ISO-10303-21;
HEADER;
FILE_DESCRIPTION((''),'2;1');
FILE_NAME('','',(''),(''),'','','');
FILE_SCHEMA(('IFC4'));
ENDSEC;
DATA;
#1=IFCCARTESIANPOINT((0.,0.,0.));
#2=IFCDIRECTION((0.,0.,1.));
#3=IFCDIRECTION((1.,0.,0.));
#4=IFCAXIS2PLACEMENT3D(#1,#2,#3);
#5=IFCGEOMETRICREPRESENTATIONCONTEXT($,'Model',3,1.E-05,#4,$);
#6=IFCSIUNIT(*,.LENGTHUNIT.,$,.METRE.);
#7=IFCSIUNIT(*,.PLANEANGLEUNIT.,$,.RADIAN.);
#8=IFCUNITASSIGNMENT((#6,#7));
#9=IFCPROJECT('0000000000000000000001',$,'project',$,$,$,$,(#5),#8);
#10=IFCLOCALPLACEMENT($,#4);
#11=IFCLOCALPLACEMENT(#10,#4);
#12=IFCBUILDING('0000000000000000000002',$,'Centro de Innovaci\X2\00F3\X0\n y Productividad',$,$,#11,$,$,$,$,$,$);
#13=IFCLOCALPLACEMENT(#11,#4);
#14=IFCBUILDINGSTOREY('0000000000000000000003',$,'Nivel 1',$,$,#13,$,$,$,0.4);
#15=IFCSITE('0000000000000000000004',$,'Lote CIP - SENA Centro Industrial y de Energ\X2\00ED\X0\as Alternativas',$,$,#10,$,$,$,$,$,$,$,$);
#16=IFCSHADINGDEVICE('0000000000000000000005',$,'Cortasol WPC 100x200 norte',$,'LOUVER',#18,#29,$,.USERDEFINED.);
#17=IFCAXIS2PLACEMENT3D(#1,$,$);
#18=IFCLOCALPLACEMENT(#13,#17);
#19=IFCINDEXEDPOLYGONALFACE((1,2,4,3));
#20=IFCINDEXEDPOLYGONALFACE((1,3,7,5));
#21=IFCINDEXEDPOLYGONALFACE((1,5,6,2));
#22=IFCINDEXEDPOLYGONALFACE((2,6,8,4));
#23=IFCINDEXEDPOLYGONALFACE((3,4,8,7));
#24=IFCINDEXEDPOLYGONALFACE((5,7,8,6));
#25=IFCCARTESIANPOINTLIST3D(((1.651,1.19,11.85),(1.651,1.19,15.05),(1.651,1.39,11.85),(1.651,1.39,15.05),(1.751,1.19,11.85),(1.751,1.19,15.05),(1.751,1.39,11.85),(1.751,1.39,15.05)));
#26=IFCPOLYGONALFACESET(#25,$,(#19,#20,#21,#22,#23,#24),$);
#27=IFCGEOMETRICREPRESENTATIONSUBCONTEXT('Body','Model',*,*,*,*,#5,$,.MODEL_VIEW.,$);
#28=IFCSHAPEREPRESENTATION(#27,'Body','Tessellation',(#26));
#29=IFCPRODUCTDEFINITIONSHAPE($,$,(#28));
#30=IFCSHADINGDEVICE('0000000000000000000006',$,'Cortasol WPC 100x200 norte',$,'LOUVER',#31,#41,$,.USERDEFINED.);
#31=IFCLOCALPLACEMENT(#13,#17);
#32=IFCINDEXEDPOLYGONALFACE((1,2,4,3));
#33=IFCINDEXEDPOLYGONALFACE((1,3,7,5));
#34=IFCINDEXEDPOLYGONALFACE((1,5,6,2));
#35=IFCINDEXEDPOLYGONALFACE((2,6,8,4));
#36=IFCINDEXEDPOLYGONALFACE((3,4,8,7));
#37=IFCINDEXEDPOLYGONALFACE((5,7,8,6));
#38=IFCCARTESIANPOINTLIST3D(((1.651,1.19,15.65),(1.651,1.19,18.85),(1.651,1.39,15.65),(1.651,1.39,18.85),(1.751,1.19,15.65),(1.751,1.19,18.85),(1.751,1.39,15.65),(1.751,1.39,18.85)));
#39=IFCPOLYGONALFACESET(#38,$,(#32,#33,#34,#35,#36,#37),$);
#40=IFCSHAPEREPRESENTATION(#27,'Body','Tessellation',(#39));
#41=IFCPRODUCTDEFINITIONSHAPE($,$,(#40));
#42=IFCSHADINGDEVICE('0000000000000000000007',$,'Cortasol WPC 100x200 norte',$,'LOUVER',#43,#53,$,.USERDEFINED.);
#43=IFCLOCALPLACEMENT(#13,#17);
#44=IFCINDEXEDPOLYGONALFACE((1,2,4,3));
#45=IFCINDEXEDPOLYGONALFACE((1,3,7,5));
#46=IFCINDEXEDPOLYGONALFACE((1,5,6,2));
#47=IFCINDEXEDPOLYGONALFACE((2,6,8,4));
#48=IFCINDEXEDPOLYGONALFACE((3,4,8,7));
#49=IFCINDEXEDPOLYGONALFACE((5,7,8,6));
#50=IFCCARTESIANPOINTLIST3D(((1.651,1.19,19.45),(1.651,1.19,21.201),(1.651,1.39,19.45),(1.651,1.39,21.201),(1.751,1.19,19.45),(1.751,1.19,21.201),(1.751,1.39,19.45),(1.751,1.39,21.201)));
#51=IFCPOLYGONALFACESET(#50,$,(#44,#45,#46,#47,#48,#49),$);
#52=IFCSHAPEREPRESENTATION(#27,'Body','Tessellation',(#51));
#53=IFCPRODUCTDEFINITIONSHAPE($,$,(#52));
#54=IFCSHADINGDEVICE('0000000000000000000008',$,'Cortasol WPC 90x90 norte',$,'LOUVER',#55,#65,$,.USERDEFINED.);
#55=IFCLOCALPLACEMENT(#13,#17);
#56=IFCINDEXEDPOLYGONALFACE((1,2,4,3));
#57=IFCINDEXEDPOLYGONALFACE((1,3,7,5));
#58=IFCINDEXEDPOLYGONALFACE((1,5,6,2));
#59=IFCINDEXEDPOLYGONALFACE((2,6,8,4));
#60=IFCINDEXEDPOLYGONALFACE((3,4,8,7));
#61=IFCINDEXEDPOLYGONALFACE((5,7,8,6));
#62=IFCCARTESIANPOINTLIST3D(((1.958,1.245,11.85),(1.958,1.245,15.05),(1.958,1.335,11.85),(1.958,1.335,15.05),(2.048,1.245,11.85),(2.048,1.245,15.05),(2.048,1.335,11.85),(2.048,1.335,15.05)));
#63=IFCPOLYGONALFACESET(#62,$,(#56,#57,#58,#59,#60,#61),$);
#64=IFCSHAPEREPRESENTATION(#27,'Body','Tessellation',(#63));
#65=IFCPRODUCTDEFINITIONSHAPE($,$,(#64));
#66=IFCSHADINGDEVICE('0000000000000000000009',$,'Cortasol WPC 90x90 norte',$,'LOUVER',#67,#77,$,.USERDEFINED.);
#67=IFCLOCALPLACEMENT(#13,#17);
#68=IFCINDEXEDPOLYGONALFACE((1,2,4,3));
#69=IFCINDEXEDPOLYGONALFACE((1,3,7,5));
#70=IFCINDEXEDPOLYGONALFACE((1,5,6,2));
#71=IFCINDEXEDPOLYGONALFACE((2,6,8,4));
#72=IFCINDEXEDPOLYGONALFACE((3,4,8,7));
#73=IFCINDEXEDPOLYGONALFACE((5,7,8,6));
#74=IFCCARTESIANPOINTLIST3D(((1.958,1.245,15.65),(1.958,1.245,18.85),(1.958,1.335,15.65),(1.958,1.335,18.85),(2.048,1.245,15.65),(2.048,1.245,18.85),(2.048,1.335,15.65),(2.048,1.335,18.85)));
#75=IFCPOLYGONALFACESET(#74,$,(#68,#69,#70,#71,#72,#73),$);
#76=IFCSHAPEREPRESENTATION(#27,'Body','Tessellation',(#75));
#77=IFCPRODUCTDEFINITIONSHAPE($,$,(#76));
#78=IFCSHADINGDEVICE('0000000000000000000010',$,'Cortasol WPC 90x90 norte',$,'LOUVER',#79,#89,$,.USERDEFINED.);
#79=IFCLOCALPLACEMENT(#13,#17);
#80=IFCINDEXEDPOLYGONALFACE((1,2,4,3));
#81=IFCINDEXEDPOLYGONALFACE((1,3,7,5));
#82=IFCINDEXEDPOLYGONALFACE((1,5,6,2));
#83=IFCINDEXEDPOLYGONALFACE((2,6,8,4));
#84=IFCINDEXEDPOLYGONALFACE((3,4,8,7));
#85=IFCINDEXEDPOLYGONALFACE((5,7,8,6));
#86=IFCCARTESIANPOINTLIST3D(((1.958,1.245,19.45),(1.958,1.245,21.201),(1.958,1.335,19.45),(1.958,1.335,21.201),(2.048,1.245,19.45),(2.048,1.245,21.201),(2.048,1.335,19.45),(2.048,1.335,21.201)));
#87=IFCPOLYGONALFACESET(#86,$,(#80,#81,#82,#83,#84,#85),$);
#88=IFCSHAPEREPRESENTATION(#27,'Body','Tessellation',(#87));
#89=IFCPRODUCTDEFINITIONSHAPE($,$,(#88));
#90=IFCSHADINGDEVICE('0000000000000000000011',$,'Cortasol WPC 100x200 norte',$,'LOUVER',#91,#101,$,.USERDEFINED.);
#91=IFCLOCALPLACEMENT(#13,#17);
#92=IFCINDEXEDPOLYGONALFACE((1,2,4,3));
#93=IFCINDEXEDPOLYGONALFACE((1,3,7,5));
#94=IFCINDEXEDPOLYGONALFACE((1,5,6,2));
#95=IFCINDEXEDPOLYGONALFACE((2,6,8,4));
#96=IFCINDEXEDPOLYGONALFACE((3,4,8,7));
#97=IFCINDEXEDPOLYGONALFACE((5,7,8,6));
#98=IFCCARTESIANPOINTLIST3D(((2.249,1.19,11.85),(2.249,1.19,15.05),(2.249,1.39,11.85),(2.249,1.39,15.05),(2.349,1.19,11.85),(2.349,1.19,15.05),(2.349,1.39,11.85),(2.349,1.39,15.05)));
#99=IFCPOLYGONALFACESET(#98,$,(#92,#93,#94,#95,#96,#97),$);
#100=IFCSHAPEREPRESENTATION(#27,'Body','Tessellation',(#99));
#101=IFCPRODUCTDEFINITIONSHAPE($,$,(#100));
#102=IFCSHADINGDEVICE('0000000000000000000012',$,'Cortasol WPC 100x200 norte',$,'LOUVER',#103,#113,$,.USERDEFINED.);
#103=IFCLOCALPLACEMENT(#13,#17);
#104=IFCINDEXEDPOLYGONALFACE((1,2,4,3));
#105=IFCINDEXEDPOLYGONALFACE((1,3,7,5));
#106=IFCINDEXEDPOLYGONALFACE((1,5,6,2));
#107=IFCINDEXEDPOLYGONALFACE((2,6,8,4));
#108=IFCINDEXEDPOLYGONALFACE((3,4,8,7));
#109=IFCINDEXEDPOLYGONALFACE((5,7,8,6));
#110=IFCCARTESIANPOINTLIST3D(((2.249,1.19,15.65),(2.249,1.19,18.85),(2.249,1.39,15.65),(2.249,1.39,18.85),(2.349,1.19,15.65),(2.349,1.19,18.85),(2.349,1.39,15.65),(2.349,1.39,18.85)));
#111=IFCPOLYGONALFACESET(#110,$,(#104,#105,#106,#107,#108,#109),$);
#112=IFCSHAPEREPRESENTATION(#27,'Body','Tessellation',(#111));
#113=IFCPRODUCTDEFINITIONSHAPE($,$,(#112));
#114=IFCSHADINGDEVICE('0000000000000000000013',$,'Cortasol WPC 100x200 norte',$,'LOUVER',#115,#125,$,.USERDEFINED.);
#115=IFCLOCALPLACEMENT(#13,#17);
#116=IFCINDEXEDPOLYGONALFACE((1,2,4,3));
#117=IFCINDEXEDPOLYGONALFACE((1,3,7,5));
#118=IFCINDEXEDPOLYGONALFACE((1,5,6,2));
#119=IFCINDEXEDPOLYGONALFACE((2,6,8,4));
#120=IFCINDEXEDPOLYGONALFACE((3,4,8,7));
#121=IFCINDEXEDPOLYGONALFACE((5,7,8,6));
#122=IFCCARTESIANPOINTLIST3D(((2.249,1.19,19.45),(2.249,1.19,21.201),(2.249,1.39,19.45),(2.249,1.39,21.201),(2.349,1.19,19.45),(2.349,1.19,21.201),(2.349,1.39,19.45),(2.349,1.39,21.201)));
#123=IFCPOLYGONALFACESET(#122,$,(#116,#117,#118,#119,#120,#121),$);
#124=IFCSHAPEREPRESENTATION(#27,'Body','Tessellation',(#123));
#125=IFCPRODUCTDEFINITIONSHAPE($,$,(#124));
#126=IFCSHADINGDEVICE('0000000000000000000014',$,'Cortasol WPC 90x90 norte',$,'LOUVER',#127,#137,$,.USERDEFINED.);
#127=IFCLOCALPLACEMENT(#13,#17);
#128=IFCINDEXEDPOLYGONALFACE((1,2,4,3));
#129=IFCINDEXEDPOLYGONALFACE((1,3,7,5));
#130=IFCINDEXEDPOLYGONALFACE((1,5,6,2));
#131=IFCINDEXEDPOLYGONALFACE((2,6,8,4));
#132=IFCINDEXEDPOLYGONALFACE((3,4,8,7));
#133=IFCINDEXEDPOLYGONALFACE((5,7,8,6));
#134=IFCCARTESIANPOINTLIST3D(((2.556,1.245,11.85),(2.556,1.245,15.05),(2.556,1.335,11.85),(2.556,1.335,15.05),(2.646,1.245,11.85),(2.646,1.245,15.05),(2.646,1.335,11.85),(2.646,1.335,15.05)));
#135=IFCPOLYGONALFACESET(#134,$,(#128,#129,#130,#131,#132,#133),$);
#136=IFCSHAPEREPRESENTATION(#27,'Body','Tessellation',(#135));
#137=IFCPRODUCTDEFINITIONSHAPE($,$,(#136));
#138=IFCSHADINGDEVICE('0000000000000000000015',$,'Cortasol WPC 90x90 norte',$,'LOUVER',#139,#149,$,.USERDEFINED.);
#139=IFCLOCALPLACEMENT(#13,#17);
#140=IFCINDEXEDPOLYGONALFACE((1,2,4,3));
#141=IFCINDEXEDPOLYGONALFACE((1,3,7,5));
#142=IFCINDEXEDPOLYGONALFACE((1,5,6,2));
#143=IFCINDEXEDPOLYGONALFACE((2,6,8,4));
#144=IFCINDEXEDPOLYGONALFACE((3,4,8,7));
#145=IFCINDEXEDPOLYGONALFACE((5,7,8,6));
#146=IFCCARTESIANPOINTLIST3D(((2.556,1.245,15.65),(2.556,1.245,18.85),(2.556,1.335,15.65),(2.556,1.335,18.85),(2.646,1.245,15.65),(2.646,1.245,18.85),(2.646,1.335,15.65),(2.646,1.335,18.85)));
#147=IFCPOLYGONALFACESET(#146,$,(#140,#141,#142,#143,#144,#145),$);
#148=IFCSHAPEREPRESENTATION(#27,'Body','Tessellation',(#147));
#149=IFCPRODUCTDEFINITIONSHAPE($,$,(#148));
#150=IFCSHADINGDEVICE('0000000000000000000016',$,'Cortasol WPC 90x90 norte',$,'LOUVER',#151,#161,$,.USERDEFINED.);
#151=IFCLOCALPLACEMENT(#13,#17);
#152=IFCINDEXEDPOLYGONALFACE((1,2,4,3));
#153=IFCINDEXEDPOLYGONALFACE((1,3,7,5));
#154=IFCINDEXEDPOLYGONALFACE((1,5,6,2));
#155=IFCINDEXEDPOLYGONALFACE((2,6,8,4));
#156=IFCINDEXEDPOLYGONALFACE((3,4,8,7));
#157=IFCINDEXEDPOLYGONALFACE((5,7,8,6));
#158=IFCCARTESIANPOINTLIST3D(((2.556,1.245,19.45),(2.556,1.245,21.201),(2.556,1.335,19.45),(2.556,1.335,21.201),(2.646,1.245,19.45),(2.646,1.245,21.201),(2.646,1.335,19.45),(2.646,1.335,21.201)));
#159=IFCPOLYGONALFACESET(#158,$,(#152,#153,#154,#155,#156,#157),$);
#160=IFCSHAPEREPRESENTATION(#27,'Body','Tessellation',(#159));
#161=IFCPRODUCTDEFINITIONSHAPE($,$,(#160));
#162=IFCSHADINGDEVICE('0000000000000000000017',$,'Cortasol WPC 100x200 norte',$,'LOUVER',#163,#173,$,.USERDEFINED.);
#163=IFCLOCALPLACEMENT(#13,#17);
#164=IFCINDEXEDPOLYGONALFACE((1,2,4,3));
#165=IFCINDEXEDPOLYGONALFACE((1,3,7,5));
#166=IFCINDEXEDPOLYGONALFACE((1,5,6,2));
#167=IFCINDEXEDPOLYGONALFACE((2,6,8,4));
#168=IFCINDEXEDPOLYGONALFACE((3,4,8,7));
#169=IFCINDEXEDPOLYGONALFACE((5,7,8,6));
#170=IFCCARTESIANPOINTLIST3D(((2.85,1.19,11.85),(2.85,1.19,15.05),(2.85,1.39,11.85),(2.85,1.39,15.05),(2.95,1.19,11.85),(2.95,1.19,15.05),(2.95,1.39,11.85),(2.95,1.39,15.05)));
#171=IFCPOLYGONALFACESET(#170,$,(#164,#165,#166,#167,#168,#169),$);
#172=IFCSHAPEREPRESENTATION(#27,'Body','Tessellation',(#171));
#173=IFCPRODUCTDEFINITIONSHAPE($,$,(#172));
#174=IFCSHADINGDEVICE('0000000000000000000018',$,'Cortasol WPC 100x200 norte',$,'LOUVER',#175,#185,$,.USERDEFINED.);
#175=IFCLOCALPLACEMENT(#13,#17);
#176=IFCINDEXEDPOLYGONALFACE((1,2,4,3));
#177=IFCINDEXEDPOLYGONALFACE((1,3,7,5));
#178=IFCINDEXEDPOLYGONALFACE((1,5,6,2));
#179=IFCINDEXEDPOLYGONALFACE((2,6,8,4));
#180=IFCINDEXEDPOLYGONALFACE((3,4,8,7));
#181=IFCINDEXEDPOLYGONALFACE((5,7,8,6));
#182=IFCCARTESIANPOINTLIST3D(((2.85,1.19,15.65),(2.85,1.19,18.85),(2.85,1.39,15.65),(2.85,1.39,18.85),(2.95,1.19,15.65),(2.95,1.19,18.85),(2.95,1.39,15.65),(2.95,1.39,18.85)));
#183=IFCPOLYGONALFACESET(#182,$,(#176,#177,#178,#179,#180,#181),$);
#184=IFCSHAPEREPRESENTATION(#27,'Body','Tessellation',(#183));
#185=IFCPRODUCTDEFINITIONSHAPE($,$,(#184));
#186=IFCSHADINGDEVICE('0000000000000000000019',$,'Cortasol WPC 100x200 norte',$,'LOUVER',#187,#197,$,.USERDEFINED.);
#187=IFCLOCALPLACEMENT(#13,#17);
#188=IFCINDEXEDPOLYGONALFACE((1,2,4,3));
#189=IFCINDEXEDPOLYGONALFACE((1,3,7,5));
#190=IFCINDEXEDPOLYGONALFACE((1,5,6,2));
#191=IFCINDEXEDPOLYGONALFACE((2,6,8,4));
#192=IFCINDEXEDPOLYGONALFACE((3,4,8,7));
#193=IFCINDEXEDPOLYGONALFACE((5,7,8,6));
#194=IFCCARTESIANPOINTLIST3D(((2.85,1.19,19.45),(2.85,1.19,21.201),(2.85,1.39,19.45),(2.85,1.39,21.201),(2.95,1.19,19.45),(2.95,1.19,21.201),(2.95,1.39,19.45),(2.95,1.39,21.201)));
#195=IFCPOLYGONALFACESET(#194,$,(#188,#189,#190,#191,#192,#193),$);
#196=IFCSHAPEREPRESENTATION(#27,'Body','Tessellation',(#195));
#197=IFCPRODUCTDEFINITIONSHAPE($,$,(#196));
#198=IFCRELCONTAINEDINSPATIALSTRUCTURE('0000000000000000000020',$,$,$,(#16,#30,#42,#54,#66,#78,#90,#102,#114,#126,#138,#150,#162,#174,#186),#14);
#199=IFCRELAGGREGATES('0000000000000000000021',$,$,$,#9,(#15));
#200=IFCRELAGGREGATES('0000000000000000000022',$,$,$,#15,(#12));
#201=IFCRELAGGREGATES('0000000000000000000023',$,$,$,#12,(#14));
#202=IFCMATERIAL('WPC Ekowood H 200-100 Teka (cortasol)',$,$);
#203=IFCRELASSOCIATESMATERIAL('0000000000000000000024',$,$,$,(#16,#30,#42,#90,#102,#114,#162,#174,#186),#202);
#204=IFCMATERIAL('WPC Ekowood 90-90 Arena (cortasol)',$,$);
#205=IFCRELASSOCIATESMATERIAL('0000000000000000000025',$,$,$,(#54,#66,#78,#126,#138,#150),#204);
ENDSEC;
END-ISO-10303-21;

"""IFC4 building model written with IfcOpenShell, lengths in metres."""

from ifc_helpers import new_model, si_unit, frame, origin_with_axes, place, context, subcontext, project, spatial, polyline, outline, extrude, material, element, save


model = new_model("IFC4")

# Units and contexts
model_context = context("Model", 3, precision=1e-05, world=origin_with_axes())
body_context = subcontext(model_context, "Body", "Model", "MODEL_VIEW")
ifc_project = project(units=[si_unit("LENGTHUNIT", "METRE"), si_unit("PLANEANGLEUNIT", "RADIAN")], contexts=[model_context])

# Site, building, storey
site_placement = place(None, origin_with_axes())
site = spatial("IfcSite", under=ifc_project, at=site_placement, Name="Lote CIP - SENA Centro Industrial y de Energías Alternativas")
building_placement = place(site_placement, origin_with_axes())
building = spatial("IfcBuilding", under=site, at=building_placement, Name="Centro de Innovación y Productividad")
storey_placement = place(building_placement, origin_with_axes())
storey = spatial("IfcBuildingStorey", under=building, at=storey_placement, Name="Nivel 1", Elevation=0.4)

# Shading devices
ifc_material_1 = material(Name="WPC Ekowood H 200-100 Teka (cortasol)")
shading_device_1_placement = place(storey_placement, origin_with_axes())
element("IfcShadingDevice", 1, at=shading_device_1_placement, inside=storey, material=ifc_material_1, Name="Cortasol WPC 100x200 norte", ObjectType="LOUVER", PredefinedType="USERDEFINED", context=body_context, shape_type="SweptSolid", body=[
    extrude(outline(polyline([(1.651, 1.19), (1.651, 1.39), (1.751, 1.39), (1.751, 1.19), (1.651, 1.19)])), frame((0.0, 0.0, 11.85)), (0.0, 0.0, 1.0), 3.2),
])
shading_device_2_placement = place(storey_placement, origin_with_axes())
element("IfcShadingDevice", 2, at=shading_device_2_placement, inside=storey, material=ifc_material_1, Name="Cortasol WPC 100x200 norte", ObjectType="LOUVER", PredefinedType="USERDEFINED", context=body_context, shape_type="SweptSolid", body=[
    extrude(outline(polyline([(1.651, 1.19), (1.651, 1.39), (1.751, 1.39), (1.751, 1.19), (1.651, 1.19)])), frame((0.0, 0.0, 15.65)), (0.0, 0.0, 1.0), 3.2),
])
shading_device_3_placement = place(storey_placement, origin_with_axes())
element("IfcShadingDevice", 3, at=shading_device_3_placement, inside=storey, material=ifc_material_1, Name="Cortasol WPC 100x200 norte", ObjectType="LOUVER", PredefinedType="USERDEFINED", context=body_context, shape_type="SweptSolid", body=[
    extrude(outline(polyline([(1.651, 1.19), (1.651, 1.39), (1.751, 1.39), (1.751, 1.19), (1.651, 1.19)])), frame((0.0, 0.0, 19.45)), (0.0, 0.0, 1.0), 1.751),
])
ifc_material_2 = material(Name="WPC Ekowood 90-90 Arena (cortasol)")
shading_device_4_placement = place(storey_placement, origin_with_axes())
element("IfcShadingDevice", 4, at=shading_device_4_placement, inside=storey, material=ifc_material_2, Name="Cortasol WPC 90x90 norte", ObjectType="LOUVER", PredefinedType="USERDEFINED", context=body_context, shape_type="SweptSolid", body=[
    extrude(outline(polyline([(1.958, 1.245), (1.958, 1.335), (2.048, 1.335), (2.048, 1.245), (1.958, 1.245)])), frame((0.0, 0.0, 11.85)), (0.0, 0.0, 1.0), 3.2),
])
shading_device_5_placement = place(storey_placement, origin_with_axes())
element("IfcShadingDevice", 5, at=shading_device_5_placement, inside=storey, material=ifc_material_2, Name="Cortasol WPC 90x90 norte", ObjectType="LOUVER", PredefinedType="USERDEFINED", context=body_context, shape_type="SweptSolid", body=[
    extrude(outline(polyline([(1.958, 1.245), (1.958, 1.335), (2.048, 1.335), (2.048, 1.245), (1.958, 1.245)])), frame((0.0, 0.0, 15.65)), (0.0, 0.0, 1.0), 3.2),
])
shading_device_6_placement = place(storey_placement, origin_with_axes())
element("IfcShadingDevice", 6, at=shading_device_6_placement, inside=storey, material=ifc_material_2, Name="Cortasol WPC 90x90 norte", ObjectType="LOUVER", PredefinedType="USERDEFINED", context=body_context, shape_type="SweptSolid", body=[
    extrude(outline(polyline([(1.958, 1.245), (1.958, 1.335), (2.048, 1.335), (2.048, 1.245), (1.958, 1.245)])), frame((0.0, 0.0, 19.45)), (0.0, 0.0, 1.0), 1.751),
])
shading_device_7_placement = place(storey_placement, origin_with_axes())
element("IfcShadingDevice", 7, at=shading_device_7_placement, inside=storey, material=ifc_material_1, Name="Cortasol WPC 100x200 norte", ObjectType="LOUVER", PredefinedType="USERDEFINED", context=body_context, shape_type="SweptSolid", body=[
    extrude(outline(polyline([(2.249, 1.19), (2.249, 1.39), (2.349, 1.39), (2.349, 1.19), (2.249, 1.19)])), frame((0.0, 0.0, 11.85)), (0.0, 0.0, 1.0), 3.2),
])
shading_device_8_placement = place(storey_placement, origin_with_axes())
element("IfcShadingDevice", 8, at=shading_device_8_placement, inside=storey, material=ifc_material_1, Name="Cortasol WPC 100x200 norte", ObjectType="LOUVER", PredefinedType="USERDEFINED", context=body_context, shape_type="SweptSolid", body=[
    extrude(outline(polyline([(2.249, 1.19), (2.249, 1.39), (2.349, 1.39), (2.349, 1.19), (2.249, 1.19)])), frame((0.0, 0.0, 15.65)), (0.0, 0.0, 1.0), 3.2),
])
shading_device_9_placement = place(storey_placement, origin_with_axes())
element("IfcShadingDevice", 9, at=shading_device_9_placement, inside=storey, material=ifc_material_1, Name="Cortasol WPC 100x200 norte", ObjectType="LOUVER", PredefinedType="USERDEFINED", context=body_context, shape_type="SweptSolid", body=[
    extrude(outline(polyline([(2.249, 1.19), (2.249, 1.39), (2.349, 1.39), (2.349, 1.19), (2.249, 1.19)])), frame((0.0, 0.0, 19.45)), (0.0, 0.0, 1.0), 1.751),
])
shading_device_10_placement = place(storey_placement, origin_with_axes())
element("IfcShadingDevice", 10, at=shading_device_10_placement, inside=storey, material=ifc_material_2, Name="Cortasol WPC 90x90 norte", ObjectType="LOUVER", PredefinedType="USERDEFINED", context=body_context, shape_type="SweptSolid", body=[
    extrude(outline(polyline([(2.556, 1.245), (2.556, 1.335), (2.646, 1.335), (2.646, 1.245), (2.556, 1.245)])), frame((0.0, 0.0, 11.85)), (0.0, 0.0, 1.0), 3.2),
])
shading_device_11_placement = place(storey_placement, origin_with_axes())
element("IfcShadingDevice", 11, at=shading_device_11_placement, inside=storey, material=ifc_material_2, Name="Cortasol WPC 90x90 norte", ObjectType="LOUVER", PredefinedType="USERDEFINED", context=body_context, shape_type="SweptSolid", body=[
    extrude(outline(polyline([(2.556, 1.245), (2.556, 1.335), (2.646, 1.335), (2.646, 1.245), (2.556, 1.245)])), frame((0.0, 0.0, 15.65)), (0.0, 0.0, 1.0), 3.2),
])
shading_device_12_placement = place(storey_placement, origin_with_axes())
element("IfcShadingDevice", 12, at=shading_device_12_placement, inside=storey, material=ifc_material_2, Name="Cortasol WPC 90x90 norte", ObjectType="LOUVER", PredefinedType="USERDEFINED", context=body_context, shape_type="SweptSolid", body=[
    extrude(outline(polyline([(2.556, 1.245), (2.556, 1.335), (2.646, 1.335), (2.646, 1.245), (2.556, 1.245)])), frame((0.0, 0.0, 19.45)), (0.0, 0.0, 1.0), 1.751),
])
shading_device_13_placement = place(storey_placement, origin_with_axes())
element("IfcShadingDevice", 13, at=shading_device_13_placement, inside=storey, material=ifc_material_1, Name="Cortasol WPC 100x200 norte", ObjectType="LOUVER", PredefinedType="USERDEFINED", context=body_context, shape_type="SweptSolid", body=[
    extrude(outline(polyline([(2.85, 1.19), (2.85, 1.39), (2.95, 1.39), (2.95, 1.19), (2.85, 1.19)])), frame((0.0, 0.0, 11.85)), (0.0, 0.0, 1.0), 3.2),
])
shading_device_14_placement = place(storey_placement, origin_with_axes())
element("IfcShadingDevice", 14, at=shading_device_14_placement, inside=storey, material=ifc_material_1, Name="Cortasol WPC 100x200 norte", ObjectType="LOUVER", PredefinedType="USERDEFINED", context=body_context, shape_type="SweptSolid", body=[
    extrude(outline(polyline([(2.85, 1.19), (2.85, 1.39), (2.95, 1.39), (2.95, 1.19), (2.85, 1.19)])), frame((0.0, 0.0, 15.65)), (0.0, 0.0, 1.0), 3.2),
])
shading_device_15_placement = place(storey_placement, origin_with_axes())
element("IfcShadingDevice", 15, at=shading_device_15_placement, inside=storey, material=ifc_material_1, Name="Cortasol WPC 100x200 norte", ObjectType="LOUVER", PredefinedType="USERDEFINED", context=body_context, shape_type="SweptSolid", body=[
    extrude(outline(polyline([(2.85, 1.19), (2.85, 1.39), (2.95, 1.39), (2.95, 1.19), (2.85, 1.19)])), frame((0.0, 0.0, 19.45)), (0.0, 0.0, 1.0), 1.751),
])

save(model, "model.ifc")
